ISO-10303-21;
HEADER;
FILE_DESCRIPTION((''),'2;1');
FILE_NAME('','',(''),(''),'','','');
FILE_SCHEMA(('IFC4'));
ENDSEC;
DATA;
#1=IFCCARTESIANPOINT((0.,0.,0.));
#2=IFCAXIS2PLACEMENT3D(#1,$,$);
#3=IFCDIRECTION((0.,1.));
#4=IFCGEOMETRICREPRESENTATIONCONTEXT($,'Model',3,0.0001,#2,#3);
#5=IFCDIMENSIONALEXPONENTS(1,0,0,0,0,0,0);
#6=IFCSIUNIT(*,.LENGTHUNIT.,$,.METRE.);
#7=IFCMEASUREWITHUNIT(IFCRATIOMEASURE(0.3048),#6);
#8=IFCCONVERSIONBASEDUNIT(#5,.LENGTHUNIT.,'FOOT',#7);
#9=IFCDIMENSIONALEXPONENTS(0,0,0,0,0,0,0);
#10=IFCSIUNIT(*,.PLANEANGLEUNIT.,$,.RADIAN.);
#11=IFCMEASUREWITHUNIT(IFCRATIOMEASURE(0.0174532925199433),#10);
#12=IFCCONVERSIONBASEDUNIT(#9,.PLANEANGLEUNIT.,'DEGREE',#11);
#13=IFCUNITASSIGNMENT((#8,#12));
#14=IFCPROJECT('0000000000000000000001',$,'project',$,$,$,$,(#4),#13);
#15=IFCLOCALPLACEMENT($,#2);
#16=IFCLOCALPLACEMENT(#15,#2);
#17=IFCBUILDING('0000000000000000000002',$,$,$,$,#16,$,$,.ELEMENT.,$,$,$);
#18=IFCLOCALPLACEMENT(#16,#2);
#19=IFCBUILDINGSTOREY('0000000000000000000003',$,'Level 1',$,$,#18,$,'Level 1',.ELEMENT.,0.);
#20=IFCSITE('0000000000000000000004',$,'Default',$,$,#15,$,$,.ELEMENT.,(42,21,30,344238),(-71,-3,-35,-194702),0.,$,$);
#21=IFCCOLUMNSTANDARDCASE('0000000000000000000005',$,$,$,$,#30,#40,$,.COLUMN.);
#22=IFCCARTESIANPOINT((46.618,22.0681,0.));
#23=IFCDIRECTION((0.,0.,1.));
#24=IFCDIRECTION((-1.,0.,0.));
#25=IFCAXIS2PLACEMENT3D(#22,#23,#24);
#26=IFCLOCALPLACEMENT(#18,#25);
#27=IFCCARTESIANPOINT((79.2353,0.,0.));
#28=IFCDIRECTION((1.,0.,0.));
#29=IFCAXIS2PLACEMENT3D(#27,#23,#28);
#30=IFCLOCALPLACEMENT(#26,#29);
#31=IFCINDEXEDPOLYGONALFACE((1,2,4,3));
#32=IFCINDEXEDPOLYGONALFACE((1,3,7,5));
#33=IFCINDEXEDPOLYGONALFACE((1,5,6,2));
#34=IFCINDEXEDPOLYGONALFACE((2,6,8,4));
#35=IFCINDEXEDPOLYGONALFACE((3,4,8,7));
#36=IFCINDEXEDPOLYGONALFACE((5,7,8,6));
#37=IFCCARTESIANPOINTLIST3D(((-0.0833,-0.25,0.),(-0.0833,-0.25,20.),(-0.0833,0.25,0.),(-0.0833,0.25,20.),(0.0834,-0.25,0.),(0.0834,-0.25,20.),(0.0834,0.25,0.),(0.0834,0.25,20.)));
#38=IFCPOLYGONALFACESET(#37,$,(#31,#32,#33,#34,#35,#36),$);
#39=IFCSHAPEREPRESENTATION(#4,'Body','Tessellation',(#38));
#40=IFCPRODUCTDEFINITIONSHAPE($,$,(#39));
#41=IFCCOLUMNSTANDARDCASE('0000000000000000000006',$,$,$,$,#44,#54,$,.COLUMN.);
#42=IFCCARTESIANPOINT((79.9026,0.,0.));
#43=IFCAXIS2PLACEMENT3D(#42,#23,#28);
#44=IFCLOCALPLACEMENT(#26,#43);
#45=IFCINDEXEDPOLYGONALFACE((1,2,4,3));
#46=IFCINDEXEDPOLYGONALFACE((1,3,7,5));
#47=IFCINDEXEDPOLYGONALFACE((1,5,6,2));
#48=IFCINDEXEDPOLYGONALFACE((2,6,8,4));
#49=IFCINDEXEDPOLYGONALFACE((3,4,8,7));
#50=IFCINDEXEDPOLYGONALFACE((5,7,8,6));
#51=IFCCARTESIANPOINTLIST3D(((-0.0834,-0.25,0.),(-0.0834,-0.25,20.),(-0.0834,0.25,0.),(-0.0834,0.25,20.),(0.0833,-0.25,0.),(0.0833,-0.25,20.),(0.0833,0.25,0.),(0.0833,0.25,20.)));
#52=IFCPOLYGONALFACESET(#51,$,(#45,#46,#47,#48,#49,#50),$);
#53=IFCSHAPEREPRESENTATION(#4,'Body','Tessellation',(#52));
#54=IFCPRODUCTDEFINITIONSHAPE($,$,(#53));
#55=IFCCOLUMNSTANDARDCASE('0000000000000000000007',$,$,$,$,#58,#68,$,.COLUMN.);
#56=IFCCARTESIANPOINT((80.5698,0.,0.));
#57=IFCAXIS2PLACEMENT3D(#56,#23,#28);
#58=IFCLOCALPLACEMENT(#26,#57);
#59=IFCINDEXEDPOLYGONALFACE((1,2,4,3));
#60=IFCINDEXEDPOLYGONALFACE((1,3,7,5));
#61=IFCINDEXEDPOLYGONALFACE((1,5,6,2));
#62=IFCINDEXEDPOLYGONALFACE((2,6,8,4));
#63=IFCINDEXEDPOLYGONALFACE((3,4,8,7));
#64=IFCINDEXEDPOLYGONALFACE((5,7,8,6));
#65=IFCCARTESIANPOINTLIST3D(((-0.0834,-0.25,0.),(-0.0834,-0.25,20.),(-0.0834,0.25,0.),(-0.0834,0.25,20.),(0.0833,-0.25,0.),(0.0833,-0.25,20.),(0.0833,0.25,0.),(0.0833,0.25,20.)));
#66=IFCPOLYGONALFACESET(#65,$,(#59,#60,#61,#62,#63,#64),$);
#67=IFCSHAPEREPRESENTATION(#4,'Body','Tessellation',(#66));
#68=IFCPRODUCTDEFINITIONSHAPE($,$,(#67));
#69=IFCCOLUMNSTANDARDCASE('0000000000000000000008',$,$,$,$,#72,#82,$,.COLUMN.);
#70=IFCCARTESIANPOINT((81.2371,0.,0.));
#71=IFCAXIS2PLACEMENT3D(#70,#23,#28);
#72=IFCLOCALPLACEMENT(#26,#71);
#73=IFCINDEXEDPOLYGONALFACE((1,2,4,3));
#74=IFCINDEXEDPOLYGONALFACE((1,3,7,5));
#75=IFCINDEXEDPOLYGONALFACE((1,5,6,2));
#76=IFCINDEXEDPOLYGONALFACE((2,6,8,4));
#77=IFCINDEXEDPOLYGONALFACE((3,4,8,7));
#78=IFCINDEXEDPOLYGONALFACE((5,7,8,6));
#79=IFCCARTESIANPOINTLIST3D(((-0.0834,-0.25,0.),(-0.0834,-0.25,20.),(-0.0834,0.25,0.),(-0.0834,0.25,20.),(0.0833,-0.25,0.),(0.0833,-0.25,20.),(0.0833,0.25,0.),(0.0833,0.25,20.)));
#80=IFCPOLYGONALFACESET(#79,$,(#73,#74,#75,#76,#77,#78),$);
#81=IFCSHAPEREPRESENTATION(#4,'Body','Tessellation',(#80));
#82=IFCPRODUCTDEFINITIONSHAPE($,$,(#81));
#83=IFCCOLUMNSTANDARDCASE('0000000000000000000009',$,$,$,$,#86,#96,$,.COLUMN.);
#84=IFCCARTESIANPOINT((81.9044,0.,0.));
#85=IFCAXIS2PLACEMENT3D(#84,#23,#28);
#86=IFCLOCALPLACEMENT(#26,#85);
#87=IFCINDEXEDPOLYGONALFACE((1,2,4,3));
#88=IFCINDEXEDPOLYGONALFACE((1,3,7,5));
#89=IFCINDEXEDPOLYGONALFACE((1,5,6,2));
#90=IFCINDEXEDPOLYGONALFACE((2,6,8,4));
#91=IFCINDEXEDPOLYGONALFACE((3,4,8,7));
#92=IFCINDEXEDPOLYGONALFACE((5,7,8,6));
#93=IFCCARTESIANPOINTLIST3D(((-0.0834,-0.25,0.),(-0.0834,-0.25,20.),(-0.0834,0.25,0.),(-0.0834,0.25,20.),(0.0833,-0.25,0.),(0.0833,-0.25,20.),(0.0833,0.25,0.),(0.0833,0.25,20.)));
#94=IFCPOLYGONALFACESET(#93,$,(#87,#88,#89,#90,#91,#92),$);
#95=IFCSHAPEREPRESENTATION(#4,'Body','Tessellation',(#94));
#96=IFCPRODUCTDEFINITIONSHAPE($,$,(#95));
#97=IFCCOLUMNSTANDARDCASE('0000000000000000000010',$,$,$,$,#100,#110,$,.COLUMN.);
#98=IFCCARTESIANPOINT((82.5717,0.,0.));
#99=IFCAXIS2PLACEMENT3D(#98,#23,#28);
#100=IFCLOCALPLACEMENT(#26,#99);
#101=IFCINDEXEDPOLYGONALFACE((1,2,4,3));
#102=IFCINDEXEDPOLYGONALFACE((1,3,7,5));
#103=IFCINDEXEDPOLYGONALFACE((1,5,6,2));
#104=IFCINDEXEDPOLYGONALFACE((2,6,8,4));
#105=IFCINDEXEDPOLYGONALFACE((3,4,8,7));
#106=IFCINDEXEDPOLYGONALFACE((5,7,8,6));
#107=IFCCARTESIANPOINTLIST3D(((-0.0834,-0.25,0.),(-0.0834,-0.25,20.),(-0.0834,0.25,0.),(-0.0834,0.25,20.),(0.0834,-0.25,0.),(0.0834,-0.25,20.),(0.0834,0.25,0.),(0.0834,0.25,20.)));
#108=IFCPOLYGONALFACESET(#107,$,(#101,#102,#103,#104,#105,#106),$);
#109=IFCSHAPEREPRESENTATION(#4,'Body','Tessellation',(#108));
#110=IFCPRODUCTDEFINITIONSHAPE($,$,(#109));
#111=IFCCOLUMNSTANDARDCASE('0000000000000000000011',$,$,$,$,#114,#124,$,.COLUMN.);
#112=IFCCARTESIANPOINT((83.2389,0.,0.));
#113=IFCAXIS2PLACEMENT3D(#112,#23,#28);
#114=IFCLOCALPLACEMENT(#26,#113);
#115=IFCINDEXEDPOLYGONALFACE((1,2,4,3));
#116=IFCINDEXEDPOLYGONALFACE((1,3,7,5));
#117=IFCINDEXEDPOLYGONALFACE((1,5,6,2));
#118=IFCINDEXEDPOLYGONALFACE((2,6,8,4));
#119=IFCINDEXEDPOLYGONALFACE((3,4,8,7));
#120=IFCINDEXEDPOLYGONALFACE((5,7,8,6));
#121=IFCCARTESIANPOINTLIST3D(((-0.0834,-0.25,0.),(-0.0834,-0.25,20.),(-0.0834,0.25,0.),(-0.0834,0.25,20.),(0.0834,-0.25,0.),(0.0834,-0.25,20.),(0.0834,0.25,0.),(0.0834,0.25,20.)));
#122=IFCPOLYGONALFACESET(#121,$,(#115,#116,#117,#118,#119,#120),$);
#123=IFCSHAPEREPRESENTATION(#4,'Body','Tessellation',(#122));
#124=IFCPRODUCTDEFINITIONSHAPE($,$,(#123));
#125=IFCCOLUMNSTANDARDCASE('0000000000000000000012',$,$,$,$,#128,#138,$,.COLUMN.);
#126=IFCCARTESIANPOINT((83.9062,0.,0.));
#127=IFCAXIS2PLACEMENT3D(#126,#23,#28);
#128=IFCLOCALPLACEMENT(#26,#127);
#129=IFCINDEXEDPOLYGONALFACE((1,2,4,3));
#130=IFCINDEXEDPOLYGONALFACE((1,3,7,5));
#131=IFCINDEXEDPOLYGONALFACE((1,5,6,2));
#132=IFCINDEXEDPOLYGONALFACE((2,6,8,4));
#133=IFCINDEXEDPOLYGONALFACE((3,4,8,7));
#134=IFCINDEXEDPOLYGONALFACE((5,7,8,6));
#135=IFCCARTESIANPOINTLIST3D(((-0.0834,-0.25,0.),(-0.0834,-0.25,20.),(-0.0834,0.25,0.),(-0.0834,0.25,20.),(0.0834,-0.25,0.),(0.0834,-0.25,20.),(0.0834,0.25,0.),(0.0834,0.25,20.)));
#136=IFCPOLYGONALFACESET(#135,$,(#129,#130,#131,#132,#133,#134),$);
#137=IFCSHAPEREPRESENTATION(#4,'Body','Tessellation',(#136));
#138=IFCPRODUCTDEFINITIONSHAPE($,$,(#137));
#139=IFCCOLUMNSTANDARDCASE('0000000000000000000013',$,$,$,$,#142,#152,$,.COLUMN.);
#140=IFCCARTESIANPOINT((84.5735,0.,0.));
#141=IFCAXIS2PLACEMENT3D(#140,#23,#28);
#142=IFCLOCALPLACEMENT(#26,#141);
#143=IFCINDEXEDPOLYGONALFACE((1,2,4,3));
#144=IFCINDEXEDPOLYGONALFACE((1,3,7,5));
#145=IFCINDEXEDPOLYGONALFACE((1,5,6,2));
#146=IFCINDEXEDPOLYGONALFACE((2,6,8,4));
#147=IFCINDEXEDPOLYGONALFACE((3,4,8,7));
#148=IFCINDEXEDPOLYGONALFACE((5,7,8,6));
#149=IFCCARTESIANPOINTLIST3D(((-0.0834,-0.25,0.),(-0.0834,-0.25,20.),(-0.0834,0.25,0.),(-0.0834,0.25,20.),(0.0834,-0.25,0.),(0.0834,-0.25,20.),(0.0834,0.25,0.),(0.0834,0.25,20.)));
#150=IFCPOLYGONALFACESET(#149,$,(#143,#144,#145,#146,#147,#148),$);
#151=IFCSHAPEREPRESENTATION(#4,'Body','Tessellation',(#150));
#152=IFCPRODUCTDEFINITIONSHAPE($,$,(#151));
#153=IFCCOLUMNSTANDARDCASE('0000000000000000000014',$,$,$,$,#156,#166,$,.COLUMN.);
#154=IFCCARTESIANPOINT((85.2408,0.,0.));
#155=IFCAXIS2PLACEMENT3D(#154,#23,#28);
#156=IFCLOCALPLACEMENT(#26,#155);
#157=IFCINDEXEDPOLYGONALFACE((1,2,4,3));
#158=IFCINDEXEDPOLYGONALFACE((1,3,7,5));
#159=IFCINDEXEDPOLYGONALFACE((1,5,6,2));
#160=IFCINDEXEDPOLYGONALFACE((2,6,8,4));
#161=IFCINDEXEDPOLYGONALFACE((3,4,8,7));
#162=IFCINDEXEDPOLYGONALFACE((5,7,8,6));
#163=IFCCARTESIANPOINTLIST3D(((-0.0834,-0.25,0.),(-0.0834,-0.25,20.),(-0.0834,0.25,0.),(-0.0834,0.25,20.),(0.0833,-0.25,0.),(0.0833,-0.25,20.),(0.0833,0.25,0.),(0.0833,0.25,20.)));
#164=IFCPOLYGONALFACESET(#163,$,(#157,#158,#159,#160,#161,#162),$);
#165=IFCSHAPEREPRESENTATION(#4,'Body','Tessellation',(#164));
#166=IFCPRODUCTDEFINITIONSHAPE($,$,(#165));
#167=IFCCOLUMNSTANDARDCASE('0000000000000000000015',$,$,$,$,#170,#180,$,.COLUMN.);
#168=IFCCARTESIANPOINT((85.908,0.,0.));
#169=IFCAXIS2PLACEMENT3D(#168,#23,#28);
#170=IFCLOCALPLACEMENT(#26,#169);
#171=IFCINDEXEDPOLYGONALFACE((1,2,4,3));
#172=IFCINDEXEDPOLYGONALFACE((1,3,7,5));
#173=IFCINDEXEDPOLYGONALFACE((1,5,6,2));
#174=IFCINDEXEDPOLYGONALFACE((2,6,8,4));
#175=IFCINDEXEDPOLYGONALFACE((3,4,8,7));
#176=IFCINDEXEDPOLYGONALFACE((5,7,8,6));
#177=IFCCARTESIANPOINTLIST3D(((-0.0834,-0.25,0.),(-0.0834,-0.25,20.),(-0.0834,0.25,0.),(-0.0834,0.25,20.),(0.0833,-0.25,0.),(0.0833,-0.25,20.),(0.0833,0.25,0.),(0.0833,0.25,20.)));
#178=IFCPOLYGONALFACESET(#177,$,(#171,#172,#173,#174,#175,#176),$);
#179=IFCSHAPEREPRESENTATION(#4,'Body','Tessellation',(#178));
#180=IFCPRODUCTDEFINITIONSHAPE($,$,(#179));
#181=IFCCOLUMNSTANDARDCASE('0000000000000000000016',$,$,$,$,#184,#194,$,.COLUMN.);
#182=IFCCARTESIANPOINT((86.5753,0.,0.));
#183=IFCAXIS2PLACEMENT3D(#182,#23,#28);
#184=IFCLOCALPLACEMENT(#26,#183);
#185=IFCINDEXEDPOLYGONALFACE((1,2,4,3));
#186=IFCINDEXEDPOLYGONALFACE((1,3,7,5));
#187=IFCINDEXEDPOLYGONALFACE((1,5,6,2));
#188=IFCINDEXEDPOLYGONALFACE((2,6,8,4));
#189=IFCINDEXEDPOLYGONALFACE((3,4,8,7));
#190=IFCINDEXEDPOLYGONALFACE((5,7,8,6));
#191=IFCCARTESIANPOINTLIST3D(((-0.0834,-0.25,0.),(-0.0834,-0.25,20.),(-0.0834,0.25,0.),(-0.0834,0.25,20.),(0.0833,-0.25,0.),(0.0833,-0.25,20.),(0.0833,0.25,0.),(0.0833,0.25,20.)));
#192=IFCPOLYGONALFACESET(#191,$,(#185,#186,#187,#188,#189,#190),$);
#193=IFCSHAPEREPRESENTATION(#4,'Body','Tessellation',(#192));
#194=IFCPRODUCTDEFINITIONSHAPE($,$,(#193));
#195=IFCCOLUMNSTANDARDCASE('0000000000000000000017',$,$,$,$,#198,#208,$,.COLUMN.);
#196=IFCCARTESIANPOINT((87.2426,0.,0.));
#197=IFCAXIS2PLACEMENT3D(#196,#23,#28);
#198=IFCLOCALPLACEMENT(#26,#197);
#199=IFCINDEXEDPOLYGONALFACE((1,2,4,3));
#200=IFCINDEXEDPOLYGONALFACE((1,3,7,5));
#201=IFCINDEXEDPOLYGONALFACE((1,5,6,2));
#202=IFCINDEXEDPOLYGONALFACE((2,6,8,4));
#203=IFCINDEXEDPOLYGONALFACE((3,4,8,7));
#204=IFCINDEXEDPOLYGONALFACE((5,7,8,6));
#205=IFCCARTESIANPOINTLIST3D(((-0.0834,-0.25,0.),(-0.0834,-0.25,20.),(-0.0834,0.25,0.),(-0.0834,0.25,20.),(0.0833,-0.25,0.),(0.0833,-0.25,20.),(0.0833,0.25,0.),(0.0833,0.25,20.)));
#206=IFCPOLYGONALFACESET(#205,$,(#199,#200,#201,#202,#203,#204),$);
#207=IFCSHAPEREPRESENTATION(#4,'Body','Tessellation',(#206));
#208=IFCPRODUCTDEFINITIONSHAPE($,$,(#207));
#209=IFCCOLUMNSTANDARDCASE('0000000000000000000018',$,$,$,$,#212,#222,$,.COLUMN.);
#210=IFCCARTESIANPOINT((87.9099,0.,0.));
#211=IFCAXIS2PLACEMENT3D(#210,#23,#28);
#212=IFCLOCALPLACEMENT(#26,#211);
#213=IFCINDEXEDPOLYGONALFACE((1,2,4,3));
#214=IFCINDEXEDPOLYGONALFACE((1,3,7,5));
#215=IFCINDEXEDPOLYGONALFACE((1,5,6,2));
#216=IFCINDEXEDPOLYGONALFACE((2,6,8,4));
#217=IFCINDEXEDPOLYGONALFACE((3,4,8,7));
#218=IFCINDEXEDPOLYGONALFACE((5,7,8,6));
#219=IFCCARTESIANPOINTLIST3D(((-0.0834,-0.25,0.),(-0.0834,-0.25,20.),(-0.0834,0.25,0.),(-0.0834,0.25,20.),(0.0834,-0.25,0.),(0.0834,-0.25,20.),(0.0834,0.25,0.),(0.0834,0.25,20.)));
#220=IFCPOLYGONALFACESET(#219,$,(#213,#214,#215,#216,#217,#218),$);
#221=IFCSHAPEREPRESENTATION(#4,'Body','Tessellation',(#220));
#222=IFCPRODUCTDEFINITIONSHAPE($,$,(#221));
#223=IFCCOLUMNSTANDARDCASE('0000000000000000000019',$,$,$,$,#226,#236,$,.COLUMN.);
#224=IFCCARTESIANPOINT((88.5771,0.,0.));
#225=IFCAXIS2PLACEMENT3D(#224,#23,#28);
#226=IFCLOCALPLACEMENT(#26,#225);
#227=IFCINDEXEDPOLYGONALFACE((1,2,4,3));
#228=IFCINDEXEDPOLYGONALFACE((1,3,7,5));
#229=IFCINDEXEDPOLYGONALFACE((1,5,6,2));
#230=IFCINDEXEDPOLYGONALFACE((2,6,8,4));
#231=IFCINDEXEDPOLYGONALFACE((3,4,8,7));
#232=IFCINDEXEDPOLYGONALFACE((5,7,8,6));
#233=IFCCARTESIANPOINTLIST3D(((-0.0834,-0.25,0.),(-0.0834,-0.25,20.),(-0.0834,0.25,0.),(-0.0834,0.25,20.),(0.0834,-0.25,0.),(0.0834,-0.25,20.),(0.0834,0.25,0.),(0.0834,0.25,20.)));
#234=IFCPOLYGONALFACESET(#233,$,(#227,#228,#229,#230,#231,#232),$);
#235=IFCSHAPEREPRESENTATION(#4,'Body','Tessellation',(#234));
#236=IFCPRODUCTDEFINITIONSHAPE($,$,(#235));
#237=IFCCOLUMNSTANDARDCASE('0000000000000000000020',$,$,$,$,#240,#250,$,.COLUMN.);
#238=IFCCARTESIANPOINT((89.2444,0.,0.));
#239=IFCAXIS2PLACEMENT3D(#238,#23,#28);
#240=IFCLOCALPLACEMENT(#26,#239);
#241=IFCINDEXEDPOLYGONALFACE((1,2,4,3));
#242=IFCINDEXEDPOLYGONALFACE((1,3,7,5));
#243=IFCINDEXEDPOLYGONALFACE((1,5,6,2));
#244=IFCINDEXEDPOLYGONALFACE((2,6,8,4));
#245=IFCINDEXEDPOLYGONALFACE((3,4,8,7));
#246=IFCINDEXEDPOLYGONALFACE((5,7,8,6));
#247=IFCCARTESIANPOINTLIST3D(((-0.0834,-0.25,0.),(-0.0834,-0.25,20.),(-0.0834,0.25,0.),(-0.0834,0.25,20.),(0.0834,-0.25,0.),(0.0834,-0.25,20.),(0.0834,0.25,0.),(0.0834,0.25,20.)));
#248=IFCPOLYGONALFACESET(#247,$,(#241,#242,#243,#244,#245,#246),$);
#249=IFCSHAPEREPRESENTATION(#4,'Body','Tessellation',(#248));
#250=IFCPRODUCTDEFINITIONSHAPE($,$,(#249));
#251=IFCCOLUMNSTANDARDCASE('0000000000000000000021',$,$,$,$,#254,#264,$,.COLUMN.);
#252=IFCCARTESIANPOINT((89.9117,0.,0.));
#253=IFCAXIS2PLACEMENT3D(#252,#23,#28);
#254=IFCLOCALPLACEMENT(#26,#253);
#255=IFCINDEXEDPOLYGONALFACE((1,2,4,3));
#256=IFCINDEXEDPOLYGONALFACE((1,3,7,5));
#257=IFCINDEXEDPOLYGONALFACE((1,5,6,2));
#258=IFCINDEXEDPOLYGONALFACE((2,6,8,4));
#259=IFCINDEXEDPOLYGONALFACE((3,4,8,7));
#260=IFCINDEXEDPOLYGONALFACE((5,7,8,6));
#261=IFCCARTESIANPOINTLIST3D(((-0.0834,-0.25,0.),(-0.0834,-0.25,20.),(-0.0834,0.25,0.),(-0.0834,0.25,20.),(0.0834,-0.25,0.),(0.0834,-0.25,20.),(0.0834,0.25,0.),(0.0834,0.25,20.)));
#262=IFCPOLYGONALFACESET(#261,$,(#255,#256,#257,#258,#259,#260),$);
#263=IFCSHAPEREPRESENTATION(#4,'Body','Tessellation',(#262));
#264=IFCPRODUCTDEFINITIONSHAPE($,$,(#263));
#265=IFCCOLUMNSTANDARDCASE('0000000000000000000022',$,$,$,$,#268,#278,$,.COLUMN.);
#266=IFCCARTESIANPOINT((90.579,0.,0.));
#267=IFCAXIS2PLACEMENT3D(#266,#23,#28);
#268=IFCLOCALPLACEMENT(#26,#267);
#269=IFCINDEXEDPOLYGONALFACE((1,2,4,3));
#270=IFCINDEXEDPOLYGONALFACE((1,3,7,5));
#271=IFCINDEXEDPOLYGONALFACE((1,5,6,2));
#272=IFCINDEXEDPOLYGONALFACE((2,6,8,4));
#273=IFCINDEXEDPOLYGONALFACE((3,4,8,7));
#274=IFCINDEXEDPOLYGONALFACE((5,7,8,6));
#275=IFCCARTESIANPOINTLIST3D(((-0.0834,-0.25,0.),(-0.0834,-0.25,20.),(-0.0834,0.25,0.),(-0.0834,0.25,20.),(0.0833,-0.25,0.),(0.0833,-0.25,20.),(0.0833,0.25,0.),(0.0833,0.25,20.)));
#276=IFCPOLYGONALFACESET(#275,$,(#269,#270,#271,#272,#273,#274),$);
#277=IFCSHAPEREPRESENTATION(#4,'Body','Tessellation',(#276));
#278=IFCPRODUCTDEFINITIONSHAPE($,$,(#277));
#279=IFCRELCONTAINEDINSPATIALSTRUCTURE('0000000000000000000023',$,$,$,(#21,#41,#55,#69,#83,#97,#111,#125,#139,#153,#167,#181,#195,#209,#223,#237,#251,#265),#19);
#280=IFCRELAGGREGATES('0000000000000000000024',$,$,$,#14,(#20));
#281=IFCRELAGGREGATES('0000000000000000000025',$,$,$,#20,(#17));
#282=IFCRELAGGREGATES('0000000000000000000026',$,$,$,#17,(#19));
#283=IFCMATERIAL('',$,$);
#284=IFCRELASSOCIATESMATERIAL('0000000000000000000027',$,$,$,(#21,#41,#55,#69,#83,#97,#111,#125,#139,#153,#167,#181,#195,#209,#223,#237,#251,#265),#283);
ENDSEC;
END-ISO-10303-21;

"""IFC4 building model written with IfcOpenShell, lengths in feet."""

from ifc_helpers import new_model, entity, si_unit, converted_unit, direction, frame, origin, place, context, project, spatial, rectangle, extrude, material, element, save


model = new_model("IFC4")

# Units and contexts
model_context = context("Model", 3, precision=0.0001, world=origin(), true_north=direction((0.0, 1.0)))
ifc_project = project(units=[converted_unit("LENGTHUNIT", "FOOT", entity("IfcRatioMeasure", 0.3048), si_unit("LENGTHUNIT", "METRE"), dimensions=[1, 0, 0, 0, 0, 0, 0]), converted_unit("PLANEANGLEUNIT", "DEGREE", entity("IfcRatioMeasure", 0.0174532925199433), si_unit("PLANEANGLEUNIT", "RADIAN"), dimensions=[0, 0, 0, 0, 0, 0, 0])], contexts=[model_context])

# Site, building, storey
site_placement = place(None, origin())
site = spatial("IfcSite", under=ifc_project, at=site_placement, Name="Default", CompositionType="ELEMENT", RefLatitude=(42, 21, 30, 344238), RefLongitude=(-71, -3, -35, -194702), RefElevation=0.0)
building_placement = place(site_placement, origin())
building = spatial("IfcBuilding", under=site, at=building_placement, CompositionType="ELEMENT")
storey_placement = place(building_placement, origin())
storey = spatial("IfcBuildingStorey", under=building, at=storey_placement, Name="Level 1", LongName="Level 1", CompositionType="ELEMENT", Elevation=0.0)

# Columns
ifc_material = material(Name="")
placement_1 = place(storey_placement, frame((46.618, 22.0681, 0.0), z_axis=(0.0, 0.0, 1.0), x_axis=(-1.0, 0.0, 0.0)))
for number, where, z_axis, x_axis in (
    (1, (79.2353, 0.0, 0.0), (0.0, 0.0, 1.0), (1.0, 0.0, 0.0)),
    (2, (79.9026, 0.0, 0.0), (0.0, 0.0, 1.0), (1.0, 0.0, 0.0)),
    (3, (80.5698, 0.0, 0.0), (0.0, 0.0, 1.0), (1.0, 0.0, 0.0)),
    (4, (81.2371, 0.0, 0.0), (0.0, 0.0, 1.0), (1.0, 0.0, 0.0)),
    (5, (81.9044, 0.0, 0.0), (0.0, 0.0, 1.0), (1.0, 0.0, 0.0)),
    (6, (82.5717, 0.0, 0.0), (0.0, 0.0, 1.0), (1.0, 0.0, 0.0)),
    (7, (83.2389, 0.0, 0.0), (0.0, 0.0, 1.0), (1.0, 0.0, 0.0)),
    (8, (83.9062, 0.0, 0.0), (0.0, 0.0, 1.0), (1.0, 0.0, 0.0)),
    (9, (84.5735, 0.0, 0.0), (0.0, 0.0, 1.0), (1.0, 0.0, 0.0)),
    (10, (85.2408, 0.0, 0.0), (0.0, 0.0, 1.0), (1.0, 0.0, 0.0)),
    (11, (85.908, 0.0, 0.0), (0.0, 0.0, 1.0), (1.0, 0.0, 0.0)),
    (12, (86.5753, 0.0, 0.0), (0.0, 0.0, 1.0), (1.0, 0.0, 0.0)),
    (13, (87.2426, 0.0, 0.0), (0.0, 0.0, 1.0), (1.0, 0.0, 0.0)),
    (14, (87.9099, 0.0, 0.0), (0.0, 0.0, 1.0), (1.0, 0.0, 0.0)),
    (15, (88.5771, 0.0, 0.0), (0.0, 0.0, 1.0), (1.0, 0.0, 0.0)),
    (16, (89.2444, 0.0, 0.0), (0.0, 0.0, 1.0), (1.0, 0.0, 0.0)),
    (17, (89.9117, 0.0, 0.0), (0.0, 0.0, 1.0), (1.0, 0.0, 0.0)),
    (18, (90.579, 0.0, 0.0), (0.0, 0.0, 1.0), (1.0, 0.0, 0.0)),
):
    element("IfcColumnStandardCase", number, at=place(placement_1, frame(where, z_axis=z_axis, x_axis=x_axis)), inside=storey, material=ifc_material, PredefinedType="COLUMN", context=model_context, shape_type="SweptSolid", body=[
        extrude(rectangle(XDim=0.1667, YDim=0.5), origin(), (0.0, 0.0, 1.0), 20.0),
    ])

save(model, "model.ifc")
